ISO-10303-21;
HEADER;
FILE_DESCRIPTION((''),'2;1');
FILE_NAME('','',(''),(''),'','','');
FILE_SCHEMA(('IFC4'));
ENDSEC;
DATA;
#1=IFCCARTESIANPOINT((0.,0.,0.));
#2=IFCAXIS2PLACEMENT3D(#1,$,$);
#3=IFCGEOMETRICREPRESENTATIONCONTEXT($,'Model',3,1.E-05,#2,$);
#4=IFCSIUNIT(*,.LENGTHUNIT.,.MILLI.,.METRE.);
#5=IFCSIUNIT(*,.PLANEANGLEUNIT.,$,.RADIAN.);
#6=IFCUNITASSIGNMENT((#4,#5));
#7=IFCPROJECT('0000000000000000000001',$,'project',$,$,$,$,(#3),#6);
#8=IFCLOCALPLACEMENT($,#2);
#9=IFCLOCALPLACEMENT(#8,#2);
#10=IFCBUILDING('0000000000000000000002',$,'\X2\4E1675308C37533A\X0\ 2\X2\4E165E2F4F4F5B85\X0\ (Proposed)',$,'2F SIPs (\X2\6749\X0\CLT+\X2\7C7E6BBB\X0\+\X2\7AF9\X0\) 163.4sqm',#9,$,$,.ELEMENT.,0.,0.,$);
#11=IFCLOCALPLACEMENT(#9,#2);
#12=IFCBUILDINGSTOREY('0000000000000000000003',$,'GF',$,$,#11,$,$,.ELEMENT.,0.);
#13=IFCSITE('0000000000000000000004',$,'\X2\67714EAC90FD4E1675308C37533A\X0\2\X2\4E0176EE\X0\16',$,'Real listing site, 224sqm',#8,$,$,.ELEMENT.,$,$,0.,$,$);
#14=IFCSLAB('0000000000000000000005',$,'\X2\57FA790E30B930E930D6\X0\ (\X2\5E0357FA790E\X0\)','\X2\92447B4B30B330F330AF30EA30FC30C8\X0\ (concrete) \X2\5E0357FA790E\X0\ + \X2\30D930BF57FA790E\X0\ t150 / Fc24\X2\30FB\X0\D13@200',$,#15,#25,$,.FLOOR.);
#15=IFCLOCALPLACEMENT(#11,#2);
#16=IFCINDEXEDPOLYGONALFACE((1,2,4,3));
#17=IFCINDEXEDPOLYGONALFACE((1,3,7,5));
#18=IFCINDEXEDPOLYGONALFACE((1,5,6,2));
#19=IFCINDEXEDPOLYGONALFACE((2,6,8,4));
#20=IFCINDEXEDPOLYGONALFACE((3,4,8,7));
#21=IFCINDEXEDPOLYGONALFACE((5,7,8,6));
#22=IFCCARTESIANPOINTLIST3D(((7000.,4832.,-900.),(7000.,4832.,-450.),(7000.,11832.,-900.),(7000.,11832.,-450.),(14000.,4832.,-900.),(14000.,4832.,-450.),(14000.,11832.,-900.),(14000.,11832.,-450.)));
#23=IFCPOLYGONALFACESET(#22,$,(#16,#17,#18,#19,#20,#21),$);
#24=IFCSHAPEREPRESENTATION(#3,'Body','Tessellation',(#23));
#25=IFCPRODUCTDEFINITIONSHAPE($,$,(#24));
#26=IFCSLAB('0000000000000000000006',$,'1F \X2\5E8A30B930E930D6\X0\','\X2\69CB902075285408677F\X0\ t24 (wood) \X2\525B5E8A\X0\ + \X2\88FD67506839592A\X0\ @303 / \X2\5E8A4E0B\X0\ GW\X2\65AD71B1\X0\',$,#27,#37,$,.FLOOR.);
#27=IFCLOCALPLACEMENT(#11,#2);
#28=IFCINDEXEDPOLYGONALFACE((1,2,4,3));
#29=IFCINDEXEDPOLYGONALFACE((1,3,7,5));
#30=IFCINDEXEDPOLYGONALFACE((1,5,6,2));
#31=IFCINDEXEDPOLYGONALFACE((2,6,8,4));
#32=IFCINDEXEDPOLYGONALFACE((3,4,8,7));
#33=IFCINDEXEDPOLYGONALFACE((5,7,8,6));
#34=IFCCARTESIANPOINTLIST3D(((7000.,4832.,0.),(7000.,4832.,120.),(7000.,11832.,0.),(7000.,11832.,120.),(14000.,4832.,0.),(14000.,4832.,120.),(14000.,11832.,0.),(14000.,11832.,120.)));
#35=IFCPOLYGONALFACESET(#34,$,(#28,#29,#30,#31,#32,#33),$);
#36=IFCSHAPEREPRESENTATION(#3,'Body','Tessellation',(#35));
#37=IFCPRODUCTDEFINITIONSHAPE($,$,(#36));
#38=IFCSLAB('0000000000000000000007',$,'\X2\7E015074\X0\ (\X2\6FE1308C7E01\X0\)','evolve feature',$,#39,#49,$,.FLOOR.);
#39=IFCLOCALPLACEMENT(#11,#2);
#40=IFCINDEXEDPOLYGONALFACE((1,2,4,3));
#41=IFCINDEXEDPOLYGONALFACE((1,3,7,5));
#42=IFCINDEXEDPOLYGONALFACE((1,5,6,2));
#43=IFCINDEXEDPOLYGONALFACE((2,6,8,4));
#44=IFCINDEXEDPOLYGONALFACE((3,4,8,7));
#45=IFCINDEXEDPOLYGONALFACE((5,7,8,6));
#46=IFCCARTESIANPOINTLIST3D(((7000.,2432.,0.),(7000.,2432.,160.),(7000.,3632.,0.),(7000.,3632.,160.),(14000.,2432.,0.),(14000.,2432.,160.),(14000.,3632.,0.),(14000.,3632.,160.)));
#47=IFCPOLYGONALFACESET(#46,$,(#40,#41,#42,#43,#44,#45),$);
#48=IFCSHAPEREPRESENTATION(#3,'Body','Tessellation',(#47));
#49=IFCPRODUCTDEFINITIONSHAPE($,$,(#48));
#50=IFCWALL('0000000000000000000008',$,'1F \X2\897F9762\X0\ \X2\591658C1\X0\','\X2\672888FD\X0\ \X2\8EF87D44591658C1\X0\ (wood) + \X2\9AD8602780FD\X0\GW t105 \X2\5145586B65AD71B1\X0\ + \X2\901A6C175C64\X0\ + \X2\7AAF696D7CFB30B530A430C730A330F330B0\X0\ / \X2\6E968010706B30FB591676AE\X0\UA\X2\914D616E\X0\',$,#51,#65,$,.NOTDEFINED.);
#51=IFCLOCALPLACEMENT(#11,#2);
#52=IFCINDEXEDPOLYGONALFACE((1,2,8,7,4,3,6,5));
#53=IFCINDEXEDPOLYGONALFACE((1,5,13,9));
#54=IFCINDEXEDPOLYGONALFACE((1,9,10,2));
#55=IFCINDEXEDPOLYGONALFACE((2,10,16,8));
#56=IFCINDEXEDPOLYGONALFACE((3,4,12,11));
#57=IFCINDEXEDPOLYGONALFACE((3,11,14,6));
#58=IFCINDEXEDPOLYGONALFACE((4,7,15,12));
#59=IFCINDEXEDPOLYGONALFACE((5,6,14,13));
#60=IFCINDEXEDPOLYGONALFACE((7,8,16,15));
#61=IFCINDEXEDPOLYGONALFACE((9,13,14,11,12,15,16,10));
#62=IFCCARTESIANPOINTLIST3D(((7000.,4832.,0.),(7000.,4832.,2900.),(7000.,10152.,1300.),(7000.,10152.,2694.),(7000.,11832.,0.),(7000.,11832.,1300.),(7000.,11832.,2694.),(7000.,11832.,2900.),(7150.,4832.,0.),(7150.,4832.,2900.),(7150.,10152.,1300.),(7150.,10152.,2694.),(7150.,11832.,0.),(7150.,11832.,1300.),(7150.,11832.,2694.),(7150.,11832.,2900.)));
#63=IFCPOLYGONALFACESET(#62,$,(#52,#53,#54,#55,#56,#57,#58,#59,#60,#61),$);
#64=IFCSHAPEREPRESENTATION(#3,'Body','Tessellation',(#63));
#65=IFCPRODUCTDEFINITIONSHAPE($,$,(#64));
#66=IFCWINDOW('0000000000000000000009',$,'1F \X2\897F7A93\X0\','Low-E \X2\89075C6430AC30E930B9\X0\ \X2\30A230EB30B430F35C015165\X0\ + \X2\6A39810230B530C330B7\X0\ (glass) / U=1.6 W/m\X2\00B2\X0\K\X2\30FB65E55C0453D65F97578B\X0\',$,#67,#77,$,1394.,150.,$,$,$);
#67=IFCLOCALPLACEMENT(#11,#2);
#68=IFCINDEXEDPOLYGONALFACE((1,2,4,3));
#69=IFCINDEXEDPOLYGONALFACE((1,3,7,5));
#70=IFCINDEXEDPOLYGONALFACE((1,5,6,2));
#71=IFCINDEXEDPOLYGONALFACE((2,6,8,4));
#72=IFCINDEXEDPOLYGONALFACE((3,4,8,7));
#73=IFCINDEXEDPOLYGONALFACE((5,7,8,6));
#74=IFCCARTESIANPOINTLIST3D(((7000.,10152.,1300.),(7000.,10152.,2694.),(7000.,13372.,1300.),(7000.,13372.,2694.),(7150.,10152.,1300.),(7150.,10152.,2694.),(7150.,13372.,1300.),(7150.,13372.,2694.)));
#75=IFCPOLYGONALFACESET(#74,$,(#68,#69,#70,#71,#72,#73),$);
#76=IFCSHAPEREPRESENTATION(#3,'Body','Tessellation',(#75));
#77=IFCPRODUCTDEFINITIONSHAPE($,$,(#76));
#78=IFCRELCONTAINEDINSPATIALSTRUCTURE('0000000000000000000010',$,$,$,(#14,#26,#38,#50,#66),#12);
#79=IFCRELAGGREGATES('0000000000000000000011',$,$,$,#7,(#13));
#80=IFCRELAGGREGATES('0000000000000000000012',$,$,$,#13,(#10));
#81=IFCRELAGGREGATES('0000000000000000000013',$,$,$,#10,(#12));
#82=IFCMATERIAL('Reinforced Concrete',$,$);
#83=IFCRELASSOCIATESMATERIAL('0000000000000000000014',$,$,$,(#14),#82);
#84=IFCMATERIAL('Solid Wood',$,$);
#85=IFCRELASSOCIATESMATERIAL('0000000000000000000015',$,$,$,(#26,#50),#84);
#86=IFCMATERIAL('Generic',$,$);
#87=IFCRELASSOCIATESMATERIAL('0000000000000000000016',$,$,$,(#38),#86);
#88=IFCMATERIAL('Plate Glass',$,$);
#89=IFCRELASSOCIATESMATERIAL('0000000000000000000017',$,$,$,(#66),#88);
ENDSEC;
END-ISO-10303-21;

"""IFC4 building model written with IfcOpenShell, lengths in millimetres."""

from ifc_helpers import new_model, si_unit, frame, frame_2d, origin, place, context, project, spatial, rectangle, extrude, material, element, fill, save


model = new_model("IFC4")

# Units and contexts
model_context = context("Model", 3, precision=1e-05, world=origin())
ifc_project = project(units=[si_unit("LENGTHUNIT", "METRE", prefix="MILLI"), si_unit("PLANEANGLEUNIT", "RADIAN")], contexts=[model_context])

# Site, building, storey
site_placement = place(None, origin())
site = spatial("IfcSite", under=ifc_project, at=site_placement, Name="東京都世田谷区2丁目16", ObjectType="Real listing site, 224sqm", CompositionType="ELEMENT", RefElevation=0.0)
building_placement = place(site_placement, origin())
building = spatial("IfcBuilding", under=site, at=building_placement, Name="世田谷区 2世帯住宅 (Proposed)", ObjectType="2F SIPs (杉CLT+籾殻+竹) 163.4sqm", CompositionType="ELEMENT", ElevationOfRefHeight=0.0, ElevationOfTerrain=0.0)
storey_placement = place(building_placement, origin())
storey = spatial("IfcBuildingStorey", under=building, at=storey_placement, Name="GF", CompositionType="ELEMENT", Elevation=0.0)

# Slabs
ifc_material_1 = material(Name="Reinforced Concrete")
slab_1_placement = place(storey_placement, frame((3500.0, 2416.0, -450.0)))
element("IfcSlab", 1, at=slab_1_placement, inside=storey, material=ifc_material_1, Name="基礎スラブ (布基礎)", Description="鉄筋コンクリート (concrete) 布基礎 + ベタ基礎 t150 / Fc24・D13@200", PredefinedType="FLOOR", context=model_context, shape_type="SweptSolid", body=[
    extrude(rectangle(XDim=7000.0, YDim=7000.0, at=frame_2d((3500.0, 3500.0))), frame((3500.0, 2416.0, -450.0)), (0.0, 0.0, 1.0), 450.0),
])
ifc_material_2 = material(Name="Solid Wood")
slab_2_placement = place(storey_placement, frame((3500.0, 2416.0, 0.0)))
element("IfcSlab", 2, at=slab_2_placement, inside=storey, material=ifc_material_2, Name="1F 床スラブ", Description="構造用合板 t24 (wood) 剛床 + 製材根太 @303 / 床下 GW断熱", PredefinedType="FLOOR", context=model_context, shape_type="SweptSolid", body=[
    extrude(rectangle(XDim=7000.0, YDim=7000.0, at=frame_2d((3500.0, 3500.0))), frame((3500.0, 2416.0, 0.0)), (0.0, 0.0, 1.0), 120.0),
])
ifc_material_3 = material(Name="Generic")
slab_3_placement = place(storey_placement, frame((3500.0, 1216.0, 0.0)))
element("IfcSlab", 3, at=slab_3_placement, inside=storey, material=ifc_material_3, Name="縁側 (濡れ縁)", Description="evolve feature", PredefinedType="FLOOR", context=model_context, shape_type="SweptSolid", body=[
    extrude(rectangle(XDim=7000.0, YDim=1200.0, at=frame_2d((3500.0, 600.0))), frame((3500.0, 1216.0, 0.0)), (0.0, 0.0, 1.0), 160.0),
])

# Shared definitions
ifc_material_4 = material(Name="Plate Glass")

# Wall, opening, window
wall_1_placement = place(storey_placement, frame((3500.0, 2416.0, 0.0)))
wall_1 = element("IfcWall", 4, at=wall_1_placement, inside=storey, material=ifc_material_2, Name="1F 西面 外壁", Description="木製 軸組外壁 (wood) + 高性能GW t105 充填断熱 + 通気層 + 窯業系サイディング / 準耐火・外皮UA配慮", PredefinedType="NOTDEFINED", context=model_context, shape_type="SweptSolid", body=[
    extrude(rectangle(XDim=150.0, YDim=7000.0, at=frame_2d((75.0, 3500.0))), frame((3500.0, 2416.0, 0.0)), (0.0, 0.0, 1.0), 2900.0),
])
opening_1_placement = place(storey_placement, frame((3500.0, 5076.0, 650.0)))
opening_1 = element("IfcOpeningElement", 5, at=opening_1_placement, cuts=wall_1, PredefinedType="NOTDEFINED", context=model_context, shape_type="SweptSolid", body=[
    extrude(rectangle(XDim=150.0, YDim=3220.0, at=frame_2d((75.0, 1610.0))), frame((3500.0, 5076.0, 650.0)), (0.0, 0.0, 1.0), 1394.0),
])
window_1_placement = place(storey_placement, frame((3500.0, 5076.0, 650.0)))
window_1 = element("IfcWindow", 6, at=window_1_placement, inside=storey, material=ifc_material_4, Name="1F 西窓", Description="Low-E 複層ガラス アルゴン封入 + 樹脂サッシ (glass) / U=1.6 W/m²K・日射取得型", OverallHeight=1394.0, OverallWidth=150.0, context=model_context, shape_type="SweptSolid", body=[
    extrude(rectangle(XDim=150.0, YDim=3220.0, at=frame_2d((75.0, 1610.0))), frame((3500.0, 5076.0, 650.0)), (0.0, 0.0, 1.0), 1394.0),
])
fill(opening_1, window_1)

save(model, "model.ifc")
